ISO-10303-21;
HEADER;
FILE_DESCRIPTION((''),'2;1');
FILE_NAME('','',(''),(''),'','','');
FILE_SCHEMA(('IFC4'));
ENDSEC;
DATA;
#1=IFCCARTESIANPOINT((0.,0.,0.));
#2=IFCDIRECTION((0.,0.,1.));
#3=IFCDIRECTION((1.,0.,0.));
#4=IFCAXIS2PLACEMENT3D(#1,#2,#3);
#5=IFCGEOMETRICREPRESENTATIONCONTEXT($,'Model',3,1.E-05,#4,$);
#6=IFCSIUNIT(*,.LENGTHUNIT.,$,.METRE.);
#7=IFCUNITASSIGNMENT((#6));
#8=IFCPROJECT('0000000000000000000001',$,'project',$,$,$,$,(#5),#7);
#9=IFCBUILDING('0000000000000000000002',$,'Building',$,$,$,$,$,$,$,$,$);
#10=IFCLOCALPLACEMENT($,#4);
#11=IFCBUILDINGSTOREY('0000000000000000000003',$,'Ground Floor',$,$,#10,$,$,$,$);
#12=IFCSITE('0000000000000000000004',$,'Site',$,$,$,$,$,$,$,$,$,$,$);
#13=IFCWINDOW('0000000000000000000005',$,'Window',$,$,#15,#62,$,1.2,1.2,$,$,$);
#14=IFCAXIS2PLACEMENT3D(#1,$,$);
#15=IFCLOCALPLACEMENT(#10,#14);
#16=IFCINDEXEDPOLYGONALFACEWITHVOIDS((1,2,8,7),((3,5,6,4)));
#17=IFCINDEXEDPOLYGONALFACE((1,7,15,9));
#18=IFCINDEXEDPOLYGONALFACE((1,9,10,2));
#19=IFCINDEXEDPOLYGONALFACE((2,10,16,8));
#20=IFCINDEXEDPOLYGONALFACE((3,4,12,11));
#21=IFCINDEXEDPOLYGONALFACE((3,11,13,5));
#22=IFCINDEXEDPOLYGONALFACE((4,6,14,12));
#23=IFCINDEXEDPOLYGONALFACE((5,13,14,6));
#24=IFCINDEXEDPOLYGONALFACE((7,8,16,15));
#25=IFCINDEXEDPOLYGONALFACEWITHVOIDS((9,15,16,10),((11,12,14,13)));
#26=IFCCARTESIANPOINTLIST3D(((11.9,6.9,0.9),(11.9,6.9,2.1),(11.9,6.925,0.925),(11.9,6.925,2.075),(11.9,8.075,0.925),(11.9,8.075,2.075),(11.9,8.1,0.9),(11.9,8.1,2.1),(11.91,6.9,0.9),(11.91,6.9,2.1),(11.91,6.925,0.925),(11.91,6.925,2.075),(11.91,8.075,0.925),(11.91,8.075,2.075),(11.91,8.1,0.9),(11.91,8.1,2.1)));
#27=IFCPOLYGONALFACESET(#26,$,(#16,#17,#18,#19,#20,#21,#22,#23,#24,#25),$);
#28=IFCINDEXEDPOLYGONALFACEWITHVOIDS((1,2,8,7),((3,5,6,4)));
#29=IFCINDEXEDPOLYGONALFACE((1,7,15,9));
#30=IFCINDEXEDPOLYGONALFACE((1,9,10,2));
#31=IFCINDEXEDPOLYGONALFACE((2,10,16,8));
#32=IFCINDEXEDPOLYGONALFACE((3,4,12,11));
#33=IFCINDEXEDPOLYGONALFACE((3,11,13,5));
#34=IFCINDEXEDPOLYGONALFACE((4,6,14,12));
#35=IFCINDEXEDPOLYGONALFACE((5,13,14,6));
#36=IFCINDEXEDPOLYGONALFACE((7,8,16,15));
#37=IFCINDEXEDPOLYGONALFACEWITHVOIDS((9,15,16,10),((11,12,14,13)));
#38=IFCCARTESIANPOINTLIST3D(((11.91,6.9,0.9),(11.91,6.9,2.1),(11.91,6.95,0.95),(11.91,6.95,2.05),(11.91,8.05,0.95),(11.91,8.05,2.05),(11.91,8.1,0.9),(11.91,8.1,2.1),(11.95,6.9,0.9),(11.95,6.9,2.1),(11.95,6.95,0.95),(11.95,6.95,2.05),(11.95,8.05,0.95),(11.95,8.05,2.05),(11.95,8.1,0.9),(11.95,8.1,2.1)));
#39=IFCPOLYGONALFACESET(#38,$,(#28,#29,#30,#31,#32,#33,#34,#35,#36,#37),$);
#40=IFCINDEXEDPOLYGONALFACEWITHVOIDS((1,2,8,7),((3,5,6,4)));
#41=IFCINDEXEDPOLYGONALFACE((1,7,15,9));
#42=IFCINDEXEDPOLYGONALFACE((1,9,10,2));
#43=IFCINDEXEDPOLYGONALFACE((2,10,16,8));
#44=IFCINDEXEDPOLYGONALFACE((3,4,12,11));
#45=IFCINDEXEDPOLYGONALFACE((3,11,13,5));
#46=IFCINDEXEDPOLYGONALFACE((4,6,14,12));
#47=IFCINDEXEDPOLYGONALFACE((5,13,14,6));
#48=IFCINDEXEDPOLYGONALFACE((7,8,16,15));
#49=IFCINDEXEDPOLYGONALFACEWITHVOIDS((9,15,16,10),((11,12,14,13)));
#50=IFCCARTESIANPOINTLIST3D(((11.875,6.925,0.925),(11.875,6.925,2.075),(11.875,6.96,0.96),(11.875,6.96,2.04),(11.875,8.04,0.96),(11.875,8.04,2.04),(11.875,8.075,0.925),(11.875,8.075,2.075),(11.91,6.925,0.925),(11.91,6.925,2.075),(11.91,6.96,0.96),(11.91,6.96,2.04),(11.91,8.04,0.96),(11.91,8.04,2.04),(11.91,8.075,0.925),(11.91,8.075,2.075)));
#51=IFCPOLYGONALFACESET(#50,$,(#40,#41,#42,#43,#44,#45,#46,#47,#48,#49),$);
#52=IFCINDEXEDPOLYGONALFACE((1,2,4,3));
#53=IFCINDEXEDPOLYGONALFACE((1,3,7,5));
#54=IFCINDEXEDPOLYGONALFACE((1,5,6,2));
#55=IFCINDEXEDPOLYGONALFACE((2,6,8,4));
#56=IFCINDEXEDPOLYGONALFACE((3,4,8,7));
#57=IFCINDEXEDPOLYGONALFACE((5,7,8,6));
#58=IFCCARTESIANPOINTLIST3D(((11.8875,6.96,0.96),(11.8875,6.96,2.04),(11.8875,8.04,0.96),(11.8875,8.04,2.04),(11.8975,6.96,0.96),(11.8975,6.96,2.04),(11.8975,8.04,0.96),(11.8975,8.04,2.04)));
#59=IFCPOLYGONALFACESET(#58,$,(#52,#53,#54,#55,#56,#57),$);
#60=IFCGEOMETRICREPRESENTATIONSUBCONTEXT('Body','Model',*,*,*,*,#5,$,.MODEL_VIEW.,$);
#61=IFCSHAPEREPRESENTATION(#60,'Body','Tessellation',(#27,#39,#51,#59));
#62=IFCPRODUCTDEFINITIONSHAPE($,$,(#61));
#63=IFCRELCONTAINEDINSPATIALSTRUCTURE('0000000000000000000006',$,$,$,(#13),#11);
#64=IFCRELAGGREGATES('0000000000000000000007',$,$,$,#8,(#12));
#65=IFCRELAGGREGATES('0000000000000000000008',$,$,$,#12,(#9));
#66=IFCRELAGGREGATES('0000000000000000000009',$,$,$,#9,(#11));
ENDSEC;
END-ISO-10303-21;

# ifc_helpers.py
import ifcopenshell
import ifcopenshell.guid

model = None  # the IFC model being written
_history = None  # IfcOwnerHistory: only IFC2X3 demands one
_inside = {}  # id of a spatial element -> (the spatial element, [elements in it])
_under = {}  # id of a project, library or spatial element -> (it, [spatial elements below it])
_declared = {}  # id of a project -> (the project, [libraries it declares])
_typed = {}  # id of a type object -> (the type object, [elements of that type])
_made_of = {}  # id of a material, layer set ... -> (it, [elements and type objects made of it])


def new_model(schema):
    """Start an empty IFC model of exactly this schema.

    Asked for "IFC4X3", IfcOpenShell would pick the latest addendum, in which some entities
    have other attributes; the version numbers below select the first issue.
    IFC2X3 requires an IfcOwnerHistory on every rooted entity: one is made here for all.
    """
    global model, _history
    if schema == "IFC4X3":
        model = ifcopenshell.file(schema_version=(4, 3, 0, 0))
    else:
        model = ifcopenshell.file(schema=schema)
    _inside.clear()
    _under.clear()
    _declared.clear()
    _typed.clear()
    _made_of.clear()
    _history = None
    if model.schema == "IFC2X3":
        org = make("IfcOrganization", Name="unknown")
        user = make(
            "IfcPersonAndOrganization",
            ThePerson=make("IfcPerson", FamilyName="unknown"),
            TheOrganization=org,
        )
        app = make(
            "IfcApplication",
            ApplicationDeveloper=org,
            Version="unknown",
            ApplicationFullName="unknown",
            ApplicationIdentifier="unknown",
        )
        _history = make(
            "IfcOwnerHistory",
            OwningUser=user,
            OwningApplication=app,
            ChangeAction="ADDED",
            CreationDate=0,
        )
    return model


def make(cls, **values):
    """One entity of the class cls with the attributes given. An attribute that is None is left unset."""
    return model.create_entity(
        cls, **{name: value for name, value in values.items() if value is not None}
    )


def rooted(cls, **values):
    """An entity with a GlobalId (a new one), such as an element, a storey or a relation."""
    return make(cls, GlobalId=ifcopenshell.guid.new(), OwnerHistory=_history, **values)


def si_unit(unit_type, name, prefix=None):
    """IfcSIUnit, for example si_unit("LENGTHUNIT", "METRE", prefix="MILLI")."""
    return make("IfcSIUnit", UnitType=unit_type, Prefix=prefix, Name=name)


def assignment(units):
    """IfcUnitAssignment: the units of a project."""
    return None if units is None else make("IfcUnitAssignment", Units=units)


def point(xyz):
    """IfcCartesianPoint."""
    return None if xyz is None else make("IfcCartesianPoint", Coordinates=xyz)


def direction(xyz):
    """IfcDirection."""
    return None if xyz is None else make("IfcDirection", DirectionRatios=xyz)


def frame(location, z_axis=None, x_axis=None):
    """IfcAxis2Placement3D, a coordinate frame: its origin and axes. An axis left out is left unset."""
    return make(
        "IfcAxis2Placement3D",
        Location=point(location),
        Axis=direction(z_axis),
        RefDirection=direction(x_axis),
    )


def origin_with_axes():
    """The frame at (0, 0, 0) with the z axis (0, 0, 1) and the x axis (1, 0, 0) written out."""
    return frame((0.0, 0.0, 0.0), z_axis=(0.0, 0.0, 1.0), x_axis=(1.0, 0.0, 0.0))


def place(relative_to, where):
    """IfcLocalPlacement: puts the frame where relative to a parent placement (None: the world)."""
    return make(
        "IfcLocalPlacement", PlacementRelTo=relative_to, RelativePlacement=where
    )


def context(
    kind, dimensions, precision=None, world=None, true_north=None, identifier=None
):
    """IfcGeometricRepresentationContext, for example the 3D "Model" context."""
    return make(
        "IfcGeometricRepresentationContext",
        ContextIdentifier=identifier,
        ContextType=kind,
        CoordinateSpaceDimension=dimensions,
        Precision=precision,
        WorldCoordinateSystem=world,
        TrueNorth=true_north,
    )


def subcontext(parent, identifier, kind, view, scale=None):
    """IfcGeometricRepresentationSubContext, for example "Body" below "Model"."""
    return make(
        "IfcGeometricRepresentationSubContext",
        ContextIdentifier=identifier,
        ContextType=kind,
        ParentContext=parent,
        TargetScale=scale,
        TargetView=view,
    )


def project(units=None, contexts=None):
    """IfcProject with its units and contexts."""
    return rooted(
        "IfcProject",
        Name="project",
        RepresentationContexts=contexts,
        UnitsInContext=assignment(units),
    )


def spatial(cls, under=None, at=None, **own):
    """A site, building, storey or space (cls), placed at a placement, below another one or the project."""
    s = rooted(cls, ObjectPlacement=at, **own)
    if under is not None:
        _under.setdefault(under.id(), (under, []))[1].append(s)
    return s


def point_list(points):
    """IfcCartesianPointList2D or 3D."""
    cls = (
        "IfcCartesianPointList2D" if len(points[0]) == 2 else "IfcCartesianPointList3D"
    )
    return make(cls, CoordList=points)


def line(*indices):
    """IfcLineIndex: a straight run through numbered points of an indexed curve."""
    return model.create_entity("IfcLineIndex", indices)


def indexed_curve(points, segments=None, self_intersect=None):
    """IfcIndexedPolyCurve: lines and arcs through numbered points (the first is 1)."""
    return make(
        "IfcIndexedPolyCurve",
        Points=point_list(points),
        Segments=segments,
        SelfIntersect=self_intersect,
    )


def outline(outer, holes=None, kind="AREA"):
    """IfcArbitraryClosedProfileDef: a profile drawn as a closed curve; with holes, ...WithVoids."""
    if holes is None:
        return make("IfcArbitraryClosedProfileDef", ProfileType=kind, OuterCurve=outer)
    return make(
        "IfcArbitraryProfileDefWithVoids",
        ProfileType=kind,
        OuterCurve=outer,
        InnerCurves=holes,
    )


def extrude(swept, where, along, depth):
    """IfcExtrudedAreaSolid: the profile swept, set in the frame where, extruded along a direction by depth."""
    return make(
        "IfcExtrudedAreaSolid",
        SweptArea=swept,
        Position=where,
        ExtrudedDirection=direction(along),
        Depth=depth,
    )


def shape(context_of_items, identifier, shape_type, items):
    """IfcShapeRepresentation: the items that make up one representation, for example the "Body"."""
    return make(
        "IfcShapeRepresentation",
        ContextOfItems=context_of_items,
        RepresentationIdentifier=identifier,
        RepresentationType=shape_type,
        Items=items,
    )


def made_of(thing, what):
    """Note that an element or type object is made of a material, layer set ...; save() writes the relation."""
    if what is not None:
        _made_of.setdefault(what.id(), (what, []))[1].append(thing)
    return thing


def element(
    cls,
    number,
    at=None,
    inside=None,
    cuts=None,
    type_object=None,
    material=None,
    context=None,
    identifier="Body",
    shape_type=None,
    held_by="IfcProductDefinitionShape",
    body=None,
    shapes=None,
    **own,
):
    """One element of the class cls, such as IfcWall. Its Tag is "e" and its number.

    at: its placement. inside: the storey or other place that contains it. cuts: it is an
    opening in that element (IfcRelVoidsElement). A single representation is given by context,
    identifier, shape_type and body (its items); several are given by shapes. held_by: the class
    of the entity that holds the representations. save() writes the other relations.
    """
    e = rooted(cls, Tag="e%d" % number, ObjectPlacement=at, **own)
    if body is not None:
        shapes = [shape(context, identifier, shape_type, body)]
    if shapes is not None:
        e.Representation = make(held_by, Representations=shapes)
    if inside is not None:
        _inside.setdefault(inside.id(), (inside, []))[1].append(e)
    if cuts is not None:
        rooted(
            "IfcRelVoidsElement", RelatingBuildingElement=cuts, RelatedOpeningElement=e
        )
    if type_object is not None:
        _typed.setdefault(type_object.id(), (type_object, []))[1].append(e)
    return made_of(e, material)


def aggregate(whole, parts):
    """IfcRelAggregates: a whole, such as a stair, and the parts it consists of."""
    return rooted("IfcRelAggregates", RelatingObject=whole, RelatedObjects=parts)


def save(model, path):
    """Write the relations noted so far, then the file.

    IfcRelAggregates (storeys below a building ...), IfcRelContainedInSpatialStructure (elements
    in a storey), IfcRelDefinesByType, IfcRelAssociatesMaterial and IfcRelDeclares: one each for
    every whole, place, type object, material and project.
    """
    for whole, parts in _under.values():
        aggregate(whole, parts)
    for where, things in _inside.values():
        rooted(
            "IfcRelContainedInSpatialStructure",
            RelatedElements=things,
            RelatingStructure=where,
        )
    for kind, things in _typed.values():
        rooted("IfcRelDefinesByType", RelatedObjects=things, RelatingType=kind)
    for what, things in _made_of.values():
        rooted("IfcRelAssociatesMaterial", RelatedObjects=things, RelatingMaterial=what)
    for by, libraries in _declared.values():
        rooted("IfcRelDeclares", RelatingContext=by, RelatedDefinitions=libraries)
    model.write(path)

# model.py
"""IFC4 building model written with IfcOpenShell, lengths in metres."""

from ifc_helpers import new_model, si_unit, frame, origin_with_axes, place, context, subcontext, project, spatial, line, indexed_curve, outline, extrude, element, save


model = new_model("IFC4")

# Units and contexts
model_context = context("Model", 3, precision=1e-05, world=origin_with_axes())
body_context = subcontext(model_context, "Body", "Model", "MODEL_VIEW")
ifc_project = project(units=[si_unit("LENGTHUNIT", "METRE")], contexts=[model_context])

# Site, building, storey
site = spatial("IfcSite", under=ifc_project, Name="Site")
building = spatial("IfcBuilding", under=site, Name="Building")
storey_placement = place(None, origin_with_axes())
storey = spatial("IfcBuildingStorey", under=building, at=storey_placement, Name="Ground Floor")

# Window
for number, where, z_axis, x_axis, name in (
    (1, (12.0, 6.9, 0.9), (0.0, 0.0, 1.0), (0.0, 1.0, 0.0), "Window"),
):
    element("IfcWindow", number, at=place(storey_placement, frame(where, z_axis=z_axis, x_axis=x_axis)), inside=storey, Name=name, OverallHeight=1.2, OverallWidth=1.2, context=body_context, shape_type="SweptSolid", body=[
        extrude(outline(indexed_curve([(0.0, 0.0), (1.2, 0.0), (1.2, 1.2), (0.0, 1.2)], segments=[line(1, 2, 3, 4, 1)]), holes=[indexed_curve([(0.025, 0.025), (1.175, 0.025), (1.175, 1.175), (0.025, 1.175)], segments=[line(1, 2, 3, 4, 1)])]), frame((0.0, 0.09, 0.0), z_axis=(0.0, -1.0, 0.0), x_axis=(1.0, 0.0, 0.0)), (0.0, 0.0, -1.0), 0.01),
        extrude(outline(indexed_curve([(0.0, 0.0), (1.2, 0.0), (1.2, 1.2), (0.0, 1.2)], segments=[line(1, 2, 3, 4, 1)]), holes=[indexed_curve([(0.05, 0.05), (1.15, 0.05), (1.15, 1.15), (0.05, 1.15)], segments=[line(1, 2, 3, 4, 1)])]), frame((0.0, 0.05, 0.0), z_axis=(0.0, -1.0, 0.0), x_axis=(1.0, 0.0, 0.0)), (0.0, 0.0, -1.0), 0.04),
        extrude(outline(indexed_curve([(0.0, 0.0), (1.15, 0.0), (1.15, 1.15), (0.0, 1.15)], segments=[line(1, 2, 3, 4, 1)]), holes=[indexed_curve([(0.035, 0.035), (1.115, 0.035), (1.115, 1.115), (0.035, 1.115)], segments=[line(1, 2, 3, 4, 1)])]), frame((0.025, 0.09, 0.025), z_axis=(0.0, -1.0, 0.0), x_axis=(1.0, 0.0, 0.0)), (0.0, 0.0, -1.0), 0.035),
        extrude(outline(indexed_curve([(0.035, 0.035), (1.115, 0.035), (1.115, 1.115), (0.035, 1.115)], segments=[line(1, 2, 3, 4, 1)])), frame((0.025, 0.1025, 0.025), z_axis=(0.0, -1.0, 0.0), x_axis=(1.0, 0.0, 0.0)), (0.0, 0.0, -1.0), 0.01),
    ])

save(model, "model.ifc")
